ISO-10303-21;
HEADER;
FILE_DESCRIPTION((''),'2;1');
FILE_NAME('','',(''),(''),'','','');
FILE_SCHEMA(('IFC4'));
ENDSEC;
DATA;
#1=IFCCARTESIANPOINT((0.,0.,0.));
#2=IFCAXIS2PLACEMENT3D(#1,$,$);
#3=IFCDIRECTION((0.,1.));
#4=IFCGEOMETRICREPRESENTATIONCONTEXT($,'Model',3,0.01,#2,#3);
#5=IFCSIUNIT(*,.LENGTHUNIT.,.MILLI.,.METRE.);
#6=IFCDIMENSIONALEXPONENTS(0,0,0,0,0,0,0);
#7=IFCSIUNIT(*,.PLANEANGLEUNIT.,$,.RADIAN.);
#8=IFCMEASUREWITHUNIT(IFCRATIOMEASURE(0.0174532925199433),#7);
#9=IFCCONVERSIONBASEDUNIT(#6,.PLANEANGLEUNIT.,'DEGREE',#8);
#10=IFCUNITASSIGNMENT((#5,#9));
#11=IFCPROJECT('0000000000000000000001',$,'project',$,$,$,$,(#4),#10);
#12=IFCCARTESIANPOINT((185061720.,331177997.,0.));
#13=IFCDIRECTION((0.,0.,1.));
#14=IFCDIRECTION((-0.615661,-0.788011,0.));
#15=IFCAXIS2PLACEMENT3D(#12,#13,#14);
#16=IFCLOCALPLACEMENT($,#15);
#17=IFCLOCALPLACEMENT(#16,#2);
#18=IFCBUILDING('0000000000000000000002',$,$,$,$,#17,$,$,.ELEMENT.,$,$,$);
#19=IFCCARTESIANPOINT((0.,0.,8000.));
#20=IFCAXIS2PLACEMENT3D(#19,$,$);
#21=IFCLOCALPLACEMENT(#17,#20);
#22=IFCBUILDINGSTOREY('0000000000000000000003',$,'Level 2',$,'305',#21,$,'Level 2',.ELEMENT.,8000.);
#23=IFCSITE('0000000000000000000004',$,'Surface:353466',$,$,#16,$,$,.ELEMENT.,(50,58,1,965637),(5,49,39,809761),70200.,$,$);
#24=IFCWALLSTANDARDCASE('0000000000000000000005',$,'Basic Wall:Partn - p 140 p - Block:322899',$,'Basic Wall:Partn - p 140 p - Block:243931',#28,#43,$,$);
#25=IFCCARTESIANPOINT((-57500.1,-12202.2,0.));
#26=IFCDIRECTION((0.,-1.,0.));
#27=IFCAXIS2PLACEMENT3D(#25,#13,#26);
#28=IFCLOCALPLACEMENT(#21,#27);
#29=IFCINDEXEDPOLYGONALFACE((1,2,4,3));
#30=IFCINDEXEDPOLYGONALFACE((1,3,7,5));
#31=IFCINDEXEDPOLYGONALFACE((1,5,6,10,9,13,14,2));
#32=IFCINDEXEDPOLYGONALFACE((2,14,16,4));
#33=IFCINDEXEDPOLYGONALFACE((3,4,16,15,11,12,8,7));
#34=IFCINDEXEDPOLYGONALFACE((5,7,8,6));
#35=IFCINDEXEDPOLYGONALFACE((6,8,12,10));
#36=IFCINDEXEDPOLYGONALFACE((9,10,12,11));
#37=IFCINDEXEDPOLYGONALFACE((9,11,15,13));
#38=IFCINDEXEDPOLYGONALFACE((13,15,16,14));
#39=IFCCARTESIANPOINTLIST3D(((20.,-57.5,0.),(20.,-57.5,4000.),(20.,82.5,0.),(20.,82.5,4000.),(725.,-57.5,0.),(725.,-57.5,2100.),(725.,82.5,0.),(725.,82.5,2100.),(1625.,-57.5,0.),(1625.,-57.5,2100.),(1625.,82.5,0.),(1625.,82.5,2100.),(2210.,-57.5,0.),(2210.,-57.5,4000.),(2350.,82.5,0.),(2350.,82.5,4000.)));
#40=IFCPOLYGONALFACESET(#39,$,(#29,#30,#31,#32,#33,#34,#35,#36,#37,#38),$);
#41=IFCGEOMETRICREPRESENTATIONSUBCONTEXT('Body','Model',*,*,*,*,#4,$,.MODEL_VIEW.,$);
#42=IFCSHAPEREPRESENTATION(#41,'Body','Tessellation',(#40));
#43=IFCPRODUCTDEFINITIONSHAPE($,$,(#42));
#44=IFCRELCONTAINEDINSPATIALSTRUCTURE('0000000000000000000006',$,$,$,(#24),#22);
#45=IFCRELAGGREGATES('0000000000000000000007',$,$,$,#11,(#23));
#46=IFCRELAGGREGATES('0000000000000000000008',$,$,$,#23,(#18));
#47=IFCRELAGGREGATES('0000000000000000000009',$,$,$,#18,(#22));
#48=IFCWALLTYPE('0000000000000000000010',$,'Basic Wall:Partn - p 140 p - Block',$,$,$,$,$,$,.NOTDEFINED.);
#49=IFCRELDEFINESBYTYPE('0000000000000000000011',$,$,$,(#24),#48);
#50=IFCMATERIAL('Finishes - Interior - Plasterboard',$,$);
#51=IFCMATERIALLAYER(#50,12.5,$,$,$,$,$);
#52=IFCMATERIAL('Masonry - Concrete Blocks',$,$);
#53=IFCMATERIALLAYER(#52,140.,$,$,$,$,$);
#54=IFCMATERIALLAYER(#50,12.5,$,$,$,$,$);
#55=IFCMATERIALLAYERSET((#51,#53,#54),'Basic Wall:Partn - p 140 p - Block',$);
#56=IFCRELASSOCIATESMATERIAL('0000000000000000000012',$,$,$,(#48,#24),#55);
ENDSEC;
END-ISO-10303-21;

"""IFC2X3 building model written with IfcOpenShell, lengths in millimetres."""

from ifc_helpers import new_model, entity, si_unit, converted_unit, direction, frame, frame_2d, origin, origin_2d_with_axis, place, context, subcontext, project, spatial, polyline, rectangle, outline, extrude, clip, halfspace, material, layer, layer_set, layer_usage, type_object, element, save


model = new_model("IFC2X3")

# Units and contexts
model_context = context("Model", 3, precision=0.01, world=origin(), true_north=direction((0.0, 1.0)))
body_context = subcontext(model_context, "Body", "Model", "MODEL_VIEW")
ifc_project = project(units=[si_unit("LENGTHUNIT", "METRE", prefix="MILLI"), converted_unit("PLANEANGLEUNIT", "DEGREE", entity("IfcRatioMeasure", 0.0174532925199433), si_unit("PLANEANGLEUNIT", "RADIAN"), dimensions=[0, 0, 0, 0, 0, 0, 0])], contexts=[model_context])

# Site, building, storey
site_placement = place(None, frame((185061720.0, 331177997.0, 0.0), z_axis=(0.0, 0.0, 1.0), x_axis=(-0.615661, -0.788011, 0.0)))
site = spatial("IfcSite", under=ifc_project, at=site_placement, Name="Surface:353466", CompositionType="ELEMENT", RefLatitude=(50, 58, 1, 965637), RefLongitude=(5, 49, 39, 809761), RefElevation=70200.0)
building_placement = place(site_placement, origin())
building = spatial("IfcBuilding", under=site, at=building_placement, CompositionType="ELEMENT")
storey_placement = place(building_placement, frame((0.0, 0.0, 8000.0)))
storey = spatial("IfcBuildingStorey", under=building, at=storey_placement, Name="Level 2", ObjectType="305", LongName="Level 2", CompositionType="ELEMENT", Elevation=8000.0)

# Shared definitions
ifc_material_1 = material(Name="Masonry - Concrete Blocks")
ifc_material_2 = material(Name="Finishes - Interior - Plasterboard")

# Wall, openings
ifc_layer_1 = layer(ifc_material_2, 12.5)
ifc_layer_2 = layer(ifc_material_1, 140.0)
ifc_layer_3 = layer(ifc_material_2, 12.5)
ifc_layer_set_1 = layer_set([ifc_layer_1, ifc_layer_2, ifc_layer_3], Name="Basic Wall:Partn - p 140 p - Block")
ifc_layer_usage_1 = layer_usage(ifc_layer_set_1, "AXIS2", "POSITIVE", -82.5)
wall_type_1 = type_object("IfcWallType", Name="Basic Wall:Partn - p 140 p - Block", PredefinedType="NOTDEFINED", material=ifc_layer_set_1)
wall_1_placement = place(storey_placement, frame((-57500.1, -12202.2, 0.0), z_axis=(0.0, 0.0, 1.0), x_axis=(0.0, -1.0, 0.0)))
wall_1 = element("IfcWallStandardCase", 1, at=wall_1_placement, inside=storey, type_object=wall_type_1, material=ifc_layer_usage_1, Name="Basic Wall:Partn - p 140 p - Block:322899", ObjectType="Basic Wall:Partn - p 140 p - Block:243931", context=body_context, shape_type="Clipping", body=[
    clip(extrude(outline(polyline([(2210.0, -57.5), (2350.0, 82.5), (20.0, 82.5), (20.0, -57.5), (2210.0, -57.5)])), origin(), (0.0, 0.0, 1.0), 4000.0), halfspace(frame((0.0, 0.0, -8000.0)), True)),
])
opening_1_placement = place(wall_1_placement, frame((1625.0, -1606.5, 0.0)))
element("IfcOpeningElement", 2, at=opening_1_placement, cuts=wall_1, ObjectType="Opening", context=body_context, shape_type="SweptSolid", body=[
    extrude(rectangle(XDim=2100.0, YDim=900.0, at=frame_2d((0.0, 0.0), x_axis=(1.0, 0.0))), frame((-450.0, 0.0, 1050.0), z_axis=(0.0, 1.0, 0.0), x_axis=(0.0, 0.0, 1.0)), (0.0, 0.0, 1.0), 3048.0),
])
opening_2_placement = place(wall_1_placement, frame((1625.0, -1606.5, 4000.0)))
element("IfcOpeningElement", 3, at=opening_2_placement, cuts=wall_1, ObjectType="Opening", context=body_context, shape_type="SweptSolid", body=[
    extrude(rectangle(XDim=2100.0, YDim=900.0, at=origin_2d_with_axis()), frame((-450.0, 0.0, 1050.0), z_axis=(0.0, 1.0, 0.0), x_axis=(0.0, 0.0, 1.0)), (0.0, 0.0, 1.0), 3048.0),
])

save(model, "model.ifc")
